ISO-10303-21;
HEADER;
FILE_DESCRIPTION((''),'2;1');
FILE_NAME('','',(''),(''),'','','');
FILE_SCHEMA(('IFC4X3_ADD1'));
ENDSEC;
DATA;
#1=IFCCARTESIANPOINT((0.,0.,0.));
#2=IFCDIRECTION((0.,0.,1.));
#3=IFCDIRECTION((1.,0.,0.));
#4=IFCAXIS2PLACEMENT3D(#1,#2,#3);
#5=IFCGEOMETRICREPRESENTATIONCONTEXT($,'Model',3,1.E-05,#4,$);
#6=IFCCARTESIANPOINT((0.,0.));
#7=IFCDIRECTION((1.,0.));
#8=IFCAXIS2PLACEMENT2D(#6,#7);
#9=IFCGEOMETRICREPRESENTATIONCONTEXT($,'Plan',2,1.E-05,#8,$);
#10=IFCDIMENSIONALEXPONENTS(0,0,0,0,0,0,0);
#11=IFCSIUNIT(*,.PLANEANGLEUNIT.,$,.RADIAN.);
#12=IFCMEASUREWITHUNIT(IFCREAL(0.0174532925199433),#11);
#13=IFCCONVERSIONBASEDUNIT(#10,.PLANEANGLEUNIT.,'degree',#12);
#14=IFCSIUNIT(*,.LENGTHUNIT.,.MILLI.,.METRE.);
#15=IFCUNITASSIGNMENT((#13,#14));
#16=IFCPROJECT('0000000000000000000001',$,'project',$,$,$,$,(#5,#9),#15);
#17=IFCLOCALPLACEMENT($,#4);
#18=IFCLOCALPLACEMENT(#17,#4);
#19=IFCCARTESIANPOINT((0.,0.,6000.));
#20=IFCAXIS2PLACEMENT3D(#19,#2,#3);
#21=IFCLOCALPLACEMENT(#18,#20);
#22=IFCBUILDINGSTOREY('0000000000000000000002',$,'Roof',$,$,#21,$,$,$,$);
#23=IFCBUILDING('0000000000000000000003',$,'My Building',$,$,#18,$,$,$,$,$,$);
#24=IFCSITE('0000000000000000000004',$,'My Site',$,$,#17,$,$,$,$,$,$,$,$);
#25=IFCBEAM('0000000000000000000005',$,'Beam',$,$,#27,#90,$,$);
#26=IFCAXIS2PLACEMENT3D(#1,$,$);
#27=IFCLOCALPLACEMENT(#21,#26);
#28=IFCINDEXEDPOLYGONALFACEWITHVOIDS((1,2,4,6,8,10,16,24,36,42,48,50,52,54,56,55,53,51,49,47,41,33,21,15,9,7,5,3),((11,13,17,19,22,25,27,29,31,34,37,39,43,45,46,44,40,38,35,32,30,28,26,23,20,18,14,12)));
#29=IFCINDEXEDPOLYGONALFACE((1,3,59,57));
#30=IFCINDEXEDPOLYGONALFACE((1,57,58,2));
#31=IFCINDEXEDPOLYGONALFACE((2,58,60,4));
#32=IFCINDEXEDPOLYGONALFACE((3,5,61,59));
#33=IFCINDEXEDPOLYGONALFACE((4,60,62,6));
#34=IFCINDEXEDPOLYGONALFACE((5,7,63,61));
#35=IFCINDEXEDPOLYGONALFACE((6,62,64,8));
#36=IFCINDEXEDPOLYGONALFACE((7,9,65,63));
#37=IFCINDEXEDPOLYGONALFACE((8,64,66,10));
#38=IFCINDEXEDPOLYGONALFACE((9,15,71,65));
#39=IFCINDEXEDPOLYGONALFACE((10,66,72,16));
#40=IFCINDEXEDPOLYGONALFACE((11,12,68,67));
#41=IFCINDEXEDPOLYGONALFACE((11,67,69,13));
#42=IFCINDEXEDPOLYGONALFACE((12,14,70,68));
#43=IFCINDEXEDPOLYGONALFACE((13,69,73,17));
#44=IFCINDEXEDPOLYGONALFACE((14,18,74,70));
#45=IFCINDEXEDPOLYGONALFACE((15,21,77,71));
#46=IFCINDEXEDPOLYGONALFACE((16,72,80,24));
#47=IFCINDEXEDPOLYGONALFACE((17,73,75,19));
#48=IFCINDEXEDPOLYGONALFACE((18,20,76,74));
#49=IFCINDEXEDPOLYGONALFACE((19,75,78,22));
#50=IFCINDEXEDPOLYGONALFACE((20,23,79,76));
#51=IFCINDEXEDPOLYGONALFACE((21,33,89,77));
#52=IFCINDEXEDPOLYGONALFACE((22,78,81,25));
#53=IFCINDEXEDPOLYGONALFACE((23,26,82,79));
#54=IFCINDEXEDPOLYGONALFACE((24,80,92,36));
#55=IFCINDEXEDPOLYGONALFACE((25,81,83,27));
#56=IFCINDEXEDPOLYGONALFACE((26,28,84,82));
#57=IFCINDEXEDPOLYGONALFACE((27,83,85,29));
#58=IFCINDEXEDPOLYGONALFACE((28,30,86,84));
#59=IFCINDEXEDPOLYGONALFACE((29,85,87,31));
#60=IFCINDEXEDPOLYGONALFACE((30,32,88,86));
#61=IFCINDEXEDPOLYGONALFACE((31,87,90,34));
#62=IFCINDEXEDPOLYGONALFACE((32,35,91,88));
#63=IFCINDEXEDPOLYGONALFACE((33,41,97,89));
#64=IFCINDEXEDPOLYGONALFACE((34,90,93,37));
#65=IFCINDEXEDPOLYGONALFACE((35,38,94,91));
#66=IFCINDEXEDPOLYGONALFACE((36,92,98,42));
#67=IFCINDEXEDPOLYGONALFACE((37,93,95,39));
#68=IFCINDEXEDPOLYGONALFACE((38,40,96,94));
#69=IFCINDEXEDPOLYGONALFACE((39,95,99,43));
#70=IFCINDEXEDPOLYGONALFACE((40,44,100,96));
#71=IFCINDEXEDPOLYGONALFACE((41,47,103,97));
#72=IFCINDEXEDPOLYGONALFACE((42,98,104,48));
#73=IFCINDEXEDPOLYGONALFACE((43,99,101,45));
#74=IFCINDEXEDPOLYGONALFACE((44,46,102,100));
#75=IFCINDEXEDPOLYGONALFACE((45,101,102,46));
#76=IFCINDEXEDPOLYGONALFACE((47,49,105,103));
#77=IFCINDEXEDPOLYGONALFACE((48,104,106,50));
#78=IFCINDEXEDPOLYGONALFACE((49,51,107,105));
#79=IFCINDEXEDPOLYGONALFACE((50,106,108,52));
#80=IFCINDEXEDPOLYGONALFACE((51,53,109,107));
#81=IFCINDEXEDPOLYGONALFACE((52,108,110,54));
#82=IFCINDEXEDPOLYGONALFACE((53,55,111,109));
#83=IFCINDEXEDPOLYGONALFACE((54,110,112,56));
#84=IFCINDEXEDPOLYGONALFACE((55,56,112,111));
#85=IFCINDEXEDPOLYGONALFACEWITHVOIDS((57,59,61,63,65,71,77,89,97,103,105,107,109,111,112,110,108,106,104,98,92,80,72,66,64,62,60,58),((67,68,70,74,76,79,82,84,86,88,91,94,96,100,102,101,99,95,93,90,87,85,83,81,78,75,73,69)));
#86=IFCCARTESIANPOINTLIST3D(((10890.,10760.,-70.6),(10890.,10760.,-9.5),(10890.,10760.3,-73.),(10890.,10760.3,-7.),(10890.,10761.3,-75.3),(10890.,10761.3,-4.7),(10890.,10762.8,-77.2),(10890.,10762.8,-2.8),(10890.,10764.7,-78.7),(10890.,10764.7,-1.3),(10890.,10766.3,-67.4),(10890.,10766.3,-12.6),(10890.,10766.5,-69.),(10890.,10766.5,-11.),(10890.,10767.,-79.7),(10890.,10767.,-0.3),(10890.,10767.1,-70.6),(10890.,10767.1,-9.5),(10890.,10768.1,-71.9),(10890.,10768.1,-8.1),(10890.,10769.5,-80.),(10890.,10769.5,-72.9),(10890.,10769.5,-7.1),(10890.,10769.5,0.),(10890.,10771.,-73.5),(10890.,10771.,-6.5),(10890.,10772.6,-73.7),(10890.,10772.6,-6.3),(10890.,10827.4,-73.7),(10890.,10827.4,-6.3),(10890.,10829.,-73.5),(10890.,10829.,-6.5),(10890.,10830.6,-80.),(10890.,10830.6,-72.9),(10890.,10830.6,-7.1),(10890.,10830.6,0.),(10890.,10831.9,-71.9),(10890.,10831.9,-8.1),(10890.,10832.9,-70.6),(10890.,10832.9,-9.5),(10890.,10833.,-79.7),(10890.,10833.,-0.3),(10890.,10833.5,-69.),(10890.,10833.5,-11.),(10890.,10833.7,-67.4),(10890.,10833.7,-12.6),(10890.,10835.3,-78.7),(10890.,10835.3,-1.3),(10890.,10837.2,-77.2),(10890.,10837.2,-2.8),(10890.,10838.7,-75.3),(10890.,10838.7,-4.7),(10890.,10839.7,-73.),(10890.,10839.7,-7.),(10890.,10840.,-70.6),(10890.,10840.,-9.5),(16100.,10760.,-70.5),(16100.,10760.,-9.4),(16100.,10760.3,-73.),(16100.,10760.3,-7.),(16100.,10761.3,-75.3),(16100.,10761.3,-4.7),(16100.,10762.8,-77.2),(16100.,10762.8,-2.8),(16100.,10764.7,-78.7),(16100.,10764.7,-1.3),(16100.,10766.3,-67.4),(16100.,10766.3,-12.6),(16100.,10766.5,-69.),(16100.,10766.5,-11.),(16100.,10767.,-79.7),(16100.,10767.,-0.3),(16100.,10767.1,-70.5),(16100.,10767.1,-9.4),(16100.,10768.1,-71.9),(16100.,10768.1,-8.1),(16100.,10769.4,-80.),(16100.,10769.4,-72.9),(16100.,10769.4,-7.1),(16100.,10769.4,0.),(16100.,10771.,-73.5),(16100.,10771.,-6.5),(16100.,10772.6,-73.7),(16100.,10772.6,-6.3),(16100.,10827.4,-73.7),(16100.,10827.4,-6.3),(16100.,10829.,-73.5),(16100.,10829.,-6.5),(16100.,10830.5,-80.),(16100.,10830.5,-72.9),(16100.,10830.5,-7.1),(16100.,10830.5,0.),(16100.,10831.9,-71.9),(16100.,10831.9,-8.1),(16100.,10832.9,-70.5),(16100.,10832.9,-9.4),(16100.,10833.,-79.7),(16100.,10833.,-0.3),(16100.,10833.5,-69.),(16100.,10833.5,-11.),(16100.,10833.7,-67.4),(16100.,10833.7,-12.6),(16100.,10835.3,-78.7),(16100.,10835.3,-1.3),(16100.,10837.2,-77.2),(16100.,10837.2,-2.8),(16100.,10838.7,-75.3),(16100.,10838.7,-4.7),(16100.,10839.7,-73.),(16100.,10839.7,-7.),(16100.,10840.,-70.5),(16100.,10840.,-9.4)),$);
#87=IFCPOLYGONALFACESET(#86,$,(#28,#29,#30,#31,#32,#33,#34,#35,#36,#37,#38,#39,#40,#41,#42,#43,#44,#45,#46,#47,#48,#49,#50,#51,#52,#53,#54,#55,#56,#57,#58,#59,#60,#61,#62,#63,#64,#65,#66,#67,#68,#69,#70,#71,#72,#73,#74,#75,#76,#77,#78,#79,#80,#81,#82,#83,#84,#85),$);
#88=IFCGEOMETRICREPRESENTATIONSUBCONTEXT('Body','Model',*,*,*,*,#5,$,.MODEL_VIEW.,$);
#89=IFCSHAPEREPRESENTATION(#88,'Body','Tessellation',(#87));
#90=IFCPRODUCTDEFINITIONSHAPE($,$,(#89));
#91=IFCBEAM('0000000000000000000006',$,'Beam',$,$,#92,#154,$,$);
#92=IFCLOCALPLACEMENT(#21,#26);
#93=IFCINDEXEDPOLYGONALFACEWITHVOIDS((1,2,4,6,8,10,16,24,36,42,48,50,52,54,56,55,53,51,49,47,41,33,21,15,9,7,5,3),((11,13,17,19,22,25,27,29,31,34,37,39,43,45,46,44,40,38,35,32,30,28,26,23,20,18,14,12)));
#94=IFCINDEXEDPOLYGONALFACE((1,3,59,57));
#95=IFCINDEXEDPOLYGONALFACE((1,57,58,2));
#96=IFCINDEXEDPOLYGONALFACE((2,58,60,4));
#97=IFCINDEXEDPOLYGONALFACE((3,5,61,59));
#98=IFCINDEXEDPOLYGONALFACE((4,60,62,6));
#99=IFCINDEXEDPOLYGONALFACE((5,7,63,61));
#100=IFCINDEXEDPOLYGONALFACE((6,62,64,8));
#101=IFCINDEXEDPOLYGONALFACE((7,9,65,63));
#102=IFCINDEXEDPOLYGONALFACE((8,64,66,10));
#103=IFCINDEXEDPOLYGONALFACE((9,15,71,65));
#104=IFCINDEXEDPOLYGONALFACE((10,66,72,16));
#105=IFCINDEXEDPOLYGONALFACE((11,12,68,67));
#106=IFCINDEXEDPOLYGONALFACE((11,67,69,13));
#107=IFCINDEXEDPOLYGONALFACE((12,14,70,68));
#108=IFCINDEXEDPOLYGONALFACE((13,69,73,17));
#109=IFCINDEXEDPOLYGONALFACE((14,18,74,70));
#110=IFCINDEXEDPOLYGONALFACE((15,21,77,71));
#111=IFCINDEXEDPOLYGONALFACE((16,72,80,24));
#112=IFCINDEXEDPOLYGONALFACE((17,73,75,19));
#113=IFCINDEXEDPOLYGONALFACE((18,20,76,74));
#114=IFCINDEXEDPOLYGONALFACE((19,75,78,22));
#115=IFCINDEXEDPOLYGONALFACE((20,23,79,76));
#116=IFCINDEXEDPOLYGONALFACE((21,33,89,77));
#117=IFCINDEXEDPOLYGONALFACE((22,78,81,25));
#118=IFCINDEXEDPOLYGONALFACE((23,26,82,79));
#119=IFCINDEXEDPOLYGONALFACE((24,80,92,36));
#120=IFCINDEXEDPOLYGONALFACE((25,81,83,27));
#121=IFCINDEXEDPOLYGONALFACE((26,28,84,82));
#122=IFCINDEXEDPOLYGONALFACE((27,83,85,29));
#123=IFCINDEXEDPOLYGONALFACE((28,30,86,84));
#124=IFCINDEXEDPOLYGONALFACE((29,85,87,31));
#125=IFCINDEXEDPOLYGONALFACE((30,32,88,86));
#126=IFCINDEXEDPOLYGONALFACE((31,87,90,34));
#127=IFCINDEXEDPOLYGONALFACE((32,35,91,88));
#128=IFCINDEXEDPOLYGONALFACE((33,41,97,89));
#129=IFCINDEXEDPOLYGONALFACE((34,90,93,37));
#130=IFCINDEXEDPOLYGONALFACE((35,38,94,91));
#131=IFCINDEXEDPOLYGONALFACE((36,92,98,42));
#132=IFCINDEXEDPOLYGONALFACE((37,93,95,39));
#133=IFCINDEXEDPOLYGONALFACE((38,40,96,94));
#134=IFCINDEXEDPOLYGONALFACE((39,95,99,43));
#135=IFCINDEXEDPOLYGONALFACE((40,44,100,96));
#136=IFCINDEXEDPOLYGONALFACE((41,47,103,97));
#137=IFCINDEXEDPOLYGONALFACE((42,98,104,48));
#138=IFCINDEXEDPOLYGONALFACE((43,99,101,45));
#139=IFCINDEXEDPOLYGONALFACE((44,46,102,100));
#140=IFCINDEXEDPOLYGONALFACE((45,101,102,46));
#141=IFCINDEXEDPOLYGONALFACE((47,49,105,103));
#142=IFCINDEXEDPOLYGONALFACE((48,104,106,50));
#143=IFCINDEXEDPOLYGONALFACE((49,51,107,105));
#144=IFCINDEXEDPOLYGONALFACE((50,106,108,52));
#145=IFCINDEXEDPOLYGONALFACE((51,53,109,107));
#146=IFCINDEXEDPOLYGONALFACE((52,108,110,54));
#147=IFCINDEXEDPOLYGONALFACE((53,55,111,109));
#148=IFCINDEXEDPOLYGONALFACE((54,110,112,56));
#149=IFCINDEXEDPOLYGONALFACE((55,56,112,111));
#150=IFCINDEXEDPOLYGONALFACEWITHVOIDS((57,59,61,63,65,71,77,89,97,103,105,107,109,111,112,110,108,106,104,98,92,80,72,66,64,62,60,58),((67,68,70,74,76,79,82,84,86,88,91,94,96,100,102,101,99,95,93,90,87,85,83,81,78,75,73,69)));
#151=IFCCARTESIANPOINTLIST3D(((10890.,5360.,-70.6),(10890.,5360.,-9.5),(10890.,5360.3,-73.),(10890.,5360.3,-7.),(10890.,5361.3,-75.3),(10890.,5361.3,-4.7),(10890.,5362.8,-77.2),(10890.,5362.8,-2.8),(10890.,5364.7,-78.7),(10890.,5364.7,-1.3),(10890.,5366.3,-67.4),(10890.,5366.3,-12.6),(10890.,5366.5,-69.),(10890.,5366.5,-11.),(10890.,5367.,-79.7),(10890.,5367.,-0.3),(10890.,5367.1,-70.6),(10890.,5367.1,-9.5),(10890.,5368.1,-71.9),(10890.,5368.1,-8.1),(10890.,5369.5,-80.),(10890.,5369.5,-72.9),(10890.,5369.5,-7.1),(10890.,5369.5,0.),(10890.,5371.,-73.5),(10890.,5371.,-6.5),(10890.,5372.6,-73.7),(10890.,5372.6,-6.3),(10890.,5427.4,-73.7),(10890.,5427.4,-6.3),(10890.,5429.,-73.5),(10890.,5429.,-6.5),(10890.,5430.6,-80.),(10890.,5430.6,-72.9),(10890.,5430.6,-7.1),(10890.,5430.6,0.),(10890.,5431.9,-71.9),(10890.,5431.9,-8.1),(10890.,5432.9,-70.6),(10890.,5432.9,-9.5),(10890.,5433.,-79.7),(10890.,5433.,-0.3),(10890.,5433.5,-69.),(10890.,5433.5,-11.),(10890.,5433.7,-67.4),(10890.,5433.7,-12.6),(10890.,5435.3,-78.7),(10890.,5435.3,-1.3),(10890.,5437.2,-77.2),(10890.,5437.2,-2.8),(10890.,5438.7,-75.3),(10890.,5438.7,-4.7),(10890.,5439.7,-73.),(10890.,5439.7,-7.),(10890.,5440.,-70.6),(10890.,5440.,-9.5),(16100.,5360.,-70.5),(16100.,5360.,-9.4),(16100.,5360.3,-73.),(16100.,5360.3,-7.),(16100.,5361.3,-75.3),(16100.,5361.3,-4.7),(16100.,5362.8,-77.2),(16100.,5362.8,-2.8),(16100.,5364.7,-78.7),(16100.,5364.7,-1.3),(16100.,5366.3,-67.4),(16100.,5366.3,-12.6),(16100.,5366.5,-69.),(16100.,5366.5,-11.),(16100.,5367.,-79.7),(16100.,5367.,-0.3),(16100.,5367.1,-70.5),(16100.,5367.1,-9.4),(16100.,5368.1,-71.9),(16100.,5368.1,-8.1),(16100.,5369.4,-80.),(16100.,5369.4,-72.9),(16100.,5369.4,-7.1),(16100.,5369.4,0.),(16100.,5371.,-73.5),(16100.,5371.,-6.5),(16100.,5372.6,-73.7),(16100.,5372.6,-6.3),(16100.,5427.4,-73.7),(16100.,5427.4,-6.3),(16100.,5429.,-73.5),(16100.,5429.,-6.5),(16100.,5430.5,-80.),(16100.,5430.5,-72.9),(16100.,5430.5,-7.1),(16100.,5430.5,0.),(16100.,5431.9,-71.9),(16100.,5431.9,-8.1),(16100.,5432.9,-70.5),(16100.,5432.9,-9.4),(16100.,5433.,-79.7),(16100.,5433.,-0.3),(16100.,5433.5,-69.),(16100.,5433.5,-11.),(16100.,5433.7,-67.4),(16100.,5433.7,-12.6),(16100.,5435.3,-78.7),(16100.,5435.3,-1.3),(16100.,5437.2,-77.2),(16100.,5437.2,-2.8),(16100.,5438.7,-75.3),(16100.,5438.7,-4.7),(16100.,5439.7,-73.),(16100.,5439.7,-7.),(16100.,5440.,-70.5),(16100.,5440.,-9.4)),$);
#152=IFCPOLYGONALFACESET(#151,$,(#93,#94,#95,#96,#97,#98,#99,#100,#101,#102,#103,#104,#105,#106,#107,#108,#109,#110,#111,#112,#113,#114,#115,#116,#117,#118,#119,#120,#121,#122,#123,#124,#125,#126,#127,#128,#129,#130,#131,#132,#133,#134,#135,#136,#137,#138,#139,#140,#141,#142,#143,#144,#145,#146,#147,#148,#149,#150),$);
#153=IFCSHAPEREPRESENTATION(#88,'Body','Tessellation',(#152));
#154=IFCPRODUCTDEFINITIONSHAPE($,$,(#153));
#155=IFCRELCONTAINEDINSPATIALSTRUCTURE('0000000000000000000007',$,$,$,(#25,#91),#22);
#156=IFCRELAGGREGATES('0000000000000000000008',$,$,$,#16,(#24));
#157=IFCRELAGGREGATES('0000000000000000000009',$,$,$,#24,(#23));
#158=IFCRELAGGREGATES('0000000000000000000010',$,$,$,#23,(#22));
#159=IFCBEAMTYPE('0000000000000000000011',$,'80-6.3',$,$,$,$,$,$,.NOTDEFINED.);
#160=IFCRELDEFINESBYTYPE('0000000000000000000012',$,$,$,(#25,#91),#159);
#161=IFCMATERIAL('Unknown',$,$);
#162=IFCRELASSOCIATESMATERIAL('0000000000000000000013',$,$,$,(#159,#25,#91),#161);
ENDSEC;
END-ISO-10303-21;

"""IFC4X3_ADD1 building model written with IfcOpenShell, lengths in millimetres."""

from ifc_helpers import new_model, entity, si_unit, converted_unit, frame, origin_with_axes, origin_2d_with_axis, place, context, subcontext, project, spatial, hollow_rectangle, extrude, material, material_profile, profile_set, profile_usage, type_object, element, save


model = new_model("IFC4X3_ADD1")

# Units and contexts
model_context = context("Model", 3, precision=1e-05, world=origin_with_axes())
plan_context = context("Plan", 2, precision=1e-05, world=origin_2d_with_axis())
body_context = subcontext(model_context, "Body", "Model", "MODEL_VIEW")
ifc_project = project(units=[converted_unit("PLANEANGLEUNIT", "degree", entity("IfcReal", 0.0174532925199433), si_unit("PLANEANGLEUNIT", "RADIAN"), dimensions=[0, 0, 0, 0, 0, 0, 0]), si_unit("LENGTHUNIT", "METRE", prefix="MILLI")], contexts=[model_context, plan_context])

# Site, building, storey
site_placement = place(None, origin_with_axes())
site = spatial("IfcSite", under=ifc_project, at=site_placement, Name="My Site")
building_placement = place(site_placement, origin_with_axes())
building = spatial("IfcBuilding", under=site, at=building_placement, Name="My Building")
storey_placement = place(building_placement, frame((0.0, 0.0, 6000.0), z_axis=(0.0, 0.0, 1.0), x_axis=(1.0, 0.0, 0.0)))
storey = spatial("IfcBuildingStorey", under=building, at=storey_placement, Name="Roof")

# Beams
ifc_material = material(Name="Unknown")
ifc_material_profile_1 = material_profile(ifc_material, hollow_rectangle(XDim=80.0, YDim=80.0, WallThickness=6.3, InnerFilletRadius=6.3, OuterFilletRadius=9.4))
ifc_profile_set_1 = profile_set([ifc_material_profile_1])
ifc_profile_usage_1 = profile_usage(ifc_profile_set_1, cardinal=8)
beam_type_1 = type_object("IfcBeamType", Name="80-6.3", PredefinedType="NOTDEFINED", material=ifc_profile_set_1)
beam_1_placement = place(storey_placement, frame((10890.0, 10800.0, 0.0), z_axis=(1.0, 0.0, 0.0), x_axis=(0.0, 1.0, 0.0)))
element("IfcBeam", 1, at=beam_1_placement, inside=storey, type_object=beam_type_1, material=ifc_profile_usage_1, Name="Beam", context=body_context, shape_type="SweptSolid", body=[
    extrude(hollow_rectangle(XDim=80.0, YDim=80.0, WallThickness=6.3, InnerFilletRadius=6.3, OuterFilletRadius=9.4), frame((0.0, -40.0, 0.0), z_axis=(0.0, 0.0, 1.0), x_axis=(1.0, 0.0, 0.0)), (0.0, 0.0, 1.0), 5210.0),
])
ifc_profile_usage_2 = profile_usage(ifc_profile_set_1, cardinal=8)
beam_2_placement = place(storey_placement, frame((10890.0, 5400.0, 0.0), z_axis=(1.0, 0.0, 0.0), x_axis=(0.0, 1.0, 0.0)))
element("IfcBeam", 2, at=beam_2_placement, inside=storey, type_object=beam_type_1, material=ifc_profile_usage_2, Name="Beam", context=body_context, shape_type="SweptSolid", body=[
    extrude(hollow_rectangle(XDim=80.0, YDim=80.0, WallThickness=6.3, InnerFilletRadius=6.3, OuterFilletRadius=9.4), frame((0.0, -40.0, 0.0), z_axis=(0.0, 0.0, 1.0), x_axis=(1.0, 0.0, 0.0)), (0.0, 0.0, 1.0), 5210.0),
])

save(model, "model.ifc")
